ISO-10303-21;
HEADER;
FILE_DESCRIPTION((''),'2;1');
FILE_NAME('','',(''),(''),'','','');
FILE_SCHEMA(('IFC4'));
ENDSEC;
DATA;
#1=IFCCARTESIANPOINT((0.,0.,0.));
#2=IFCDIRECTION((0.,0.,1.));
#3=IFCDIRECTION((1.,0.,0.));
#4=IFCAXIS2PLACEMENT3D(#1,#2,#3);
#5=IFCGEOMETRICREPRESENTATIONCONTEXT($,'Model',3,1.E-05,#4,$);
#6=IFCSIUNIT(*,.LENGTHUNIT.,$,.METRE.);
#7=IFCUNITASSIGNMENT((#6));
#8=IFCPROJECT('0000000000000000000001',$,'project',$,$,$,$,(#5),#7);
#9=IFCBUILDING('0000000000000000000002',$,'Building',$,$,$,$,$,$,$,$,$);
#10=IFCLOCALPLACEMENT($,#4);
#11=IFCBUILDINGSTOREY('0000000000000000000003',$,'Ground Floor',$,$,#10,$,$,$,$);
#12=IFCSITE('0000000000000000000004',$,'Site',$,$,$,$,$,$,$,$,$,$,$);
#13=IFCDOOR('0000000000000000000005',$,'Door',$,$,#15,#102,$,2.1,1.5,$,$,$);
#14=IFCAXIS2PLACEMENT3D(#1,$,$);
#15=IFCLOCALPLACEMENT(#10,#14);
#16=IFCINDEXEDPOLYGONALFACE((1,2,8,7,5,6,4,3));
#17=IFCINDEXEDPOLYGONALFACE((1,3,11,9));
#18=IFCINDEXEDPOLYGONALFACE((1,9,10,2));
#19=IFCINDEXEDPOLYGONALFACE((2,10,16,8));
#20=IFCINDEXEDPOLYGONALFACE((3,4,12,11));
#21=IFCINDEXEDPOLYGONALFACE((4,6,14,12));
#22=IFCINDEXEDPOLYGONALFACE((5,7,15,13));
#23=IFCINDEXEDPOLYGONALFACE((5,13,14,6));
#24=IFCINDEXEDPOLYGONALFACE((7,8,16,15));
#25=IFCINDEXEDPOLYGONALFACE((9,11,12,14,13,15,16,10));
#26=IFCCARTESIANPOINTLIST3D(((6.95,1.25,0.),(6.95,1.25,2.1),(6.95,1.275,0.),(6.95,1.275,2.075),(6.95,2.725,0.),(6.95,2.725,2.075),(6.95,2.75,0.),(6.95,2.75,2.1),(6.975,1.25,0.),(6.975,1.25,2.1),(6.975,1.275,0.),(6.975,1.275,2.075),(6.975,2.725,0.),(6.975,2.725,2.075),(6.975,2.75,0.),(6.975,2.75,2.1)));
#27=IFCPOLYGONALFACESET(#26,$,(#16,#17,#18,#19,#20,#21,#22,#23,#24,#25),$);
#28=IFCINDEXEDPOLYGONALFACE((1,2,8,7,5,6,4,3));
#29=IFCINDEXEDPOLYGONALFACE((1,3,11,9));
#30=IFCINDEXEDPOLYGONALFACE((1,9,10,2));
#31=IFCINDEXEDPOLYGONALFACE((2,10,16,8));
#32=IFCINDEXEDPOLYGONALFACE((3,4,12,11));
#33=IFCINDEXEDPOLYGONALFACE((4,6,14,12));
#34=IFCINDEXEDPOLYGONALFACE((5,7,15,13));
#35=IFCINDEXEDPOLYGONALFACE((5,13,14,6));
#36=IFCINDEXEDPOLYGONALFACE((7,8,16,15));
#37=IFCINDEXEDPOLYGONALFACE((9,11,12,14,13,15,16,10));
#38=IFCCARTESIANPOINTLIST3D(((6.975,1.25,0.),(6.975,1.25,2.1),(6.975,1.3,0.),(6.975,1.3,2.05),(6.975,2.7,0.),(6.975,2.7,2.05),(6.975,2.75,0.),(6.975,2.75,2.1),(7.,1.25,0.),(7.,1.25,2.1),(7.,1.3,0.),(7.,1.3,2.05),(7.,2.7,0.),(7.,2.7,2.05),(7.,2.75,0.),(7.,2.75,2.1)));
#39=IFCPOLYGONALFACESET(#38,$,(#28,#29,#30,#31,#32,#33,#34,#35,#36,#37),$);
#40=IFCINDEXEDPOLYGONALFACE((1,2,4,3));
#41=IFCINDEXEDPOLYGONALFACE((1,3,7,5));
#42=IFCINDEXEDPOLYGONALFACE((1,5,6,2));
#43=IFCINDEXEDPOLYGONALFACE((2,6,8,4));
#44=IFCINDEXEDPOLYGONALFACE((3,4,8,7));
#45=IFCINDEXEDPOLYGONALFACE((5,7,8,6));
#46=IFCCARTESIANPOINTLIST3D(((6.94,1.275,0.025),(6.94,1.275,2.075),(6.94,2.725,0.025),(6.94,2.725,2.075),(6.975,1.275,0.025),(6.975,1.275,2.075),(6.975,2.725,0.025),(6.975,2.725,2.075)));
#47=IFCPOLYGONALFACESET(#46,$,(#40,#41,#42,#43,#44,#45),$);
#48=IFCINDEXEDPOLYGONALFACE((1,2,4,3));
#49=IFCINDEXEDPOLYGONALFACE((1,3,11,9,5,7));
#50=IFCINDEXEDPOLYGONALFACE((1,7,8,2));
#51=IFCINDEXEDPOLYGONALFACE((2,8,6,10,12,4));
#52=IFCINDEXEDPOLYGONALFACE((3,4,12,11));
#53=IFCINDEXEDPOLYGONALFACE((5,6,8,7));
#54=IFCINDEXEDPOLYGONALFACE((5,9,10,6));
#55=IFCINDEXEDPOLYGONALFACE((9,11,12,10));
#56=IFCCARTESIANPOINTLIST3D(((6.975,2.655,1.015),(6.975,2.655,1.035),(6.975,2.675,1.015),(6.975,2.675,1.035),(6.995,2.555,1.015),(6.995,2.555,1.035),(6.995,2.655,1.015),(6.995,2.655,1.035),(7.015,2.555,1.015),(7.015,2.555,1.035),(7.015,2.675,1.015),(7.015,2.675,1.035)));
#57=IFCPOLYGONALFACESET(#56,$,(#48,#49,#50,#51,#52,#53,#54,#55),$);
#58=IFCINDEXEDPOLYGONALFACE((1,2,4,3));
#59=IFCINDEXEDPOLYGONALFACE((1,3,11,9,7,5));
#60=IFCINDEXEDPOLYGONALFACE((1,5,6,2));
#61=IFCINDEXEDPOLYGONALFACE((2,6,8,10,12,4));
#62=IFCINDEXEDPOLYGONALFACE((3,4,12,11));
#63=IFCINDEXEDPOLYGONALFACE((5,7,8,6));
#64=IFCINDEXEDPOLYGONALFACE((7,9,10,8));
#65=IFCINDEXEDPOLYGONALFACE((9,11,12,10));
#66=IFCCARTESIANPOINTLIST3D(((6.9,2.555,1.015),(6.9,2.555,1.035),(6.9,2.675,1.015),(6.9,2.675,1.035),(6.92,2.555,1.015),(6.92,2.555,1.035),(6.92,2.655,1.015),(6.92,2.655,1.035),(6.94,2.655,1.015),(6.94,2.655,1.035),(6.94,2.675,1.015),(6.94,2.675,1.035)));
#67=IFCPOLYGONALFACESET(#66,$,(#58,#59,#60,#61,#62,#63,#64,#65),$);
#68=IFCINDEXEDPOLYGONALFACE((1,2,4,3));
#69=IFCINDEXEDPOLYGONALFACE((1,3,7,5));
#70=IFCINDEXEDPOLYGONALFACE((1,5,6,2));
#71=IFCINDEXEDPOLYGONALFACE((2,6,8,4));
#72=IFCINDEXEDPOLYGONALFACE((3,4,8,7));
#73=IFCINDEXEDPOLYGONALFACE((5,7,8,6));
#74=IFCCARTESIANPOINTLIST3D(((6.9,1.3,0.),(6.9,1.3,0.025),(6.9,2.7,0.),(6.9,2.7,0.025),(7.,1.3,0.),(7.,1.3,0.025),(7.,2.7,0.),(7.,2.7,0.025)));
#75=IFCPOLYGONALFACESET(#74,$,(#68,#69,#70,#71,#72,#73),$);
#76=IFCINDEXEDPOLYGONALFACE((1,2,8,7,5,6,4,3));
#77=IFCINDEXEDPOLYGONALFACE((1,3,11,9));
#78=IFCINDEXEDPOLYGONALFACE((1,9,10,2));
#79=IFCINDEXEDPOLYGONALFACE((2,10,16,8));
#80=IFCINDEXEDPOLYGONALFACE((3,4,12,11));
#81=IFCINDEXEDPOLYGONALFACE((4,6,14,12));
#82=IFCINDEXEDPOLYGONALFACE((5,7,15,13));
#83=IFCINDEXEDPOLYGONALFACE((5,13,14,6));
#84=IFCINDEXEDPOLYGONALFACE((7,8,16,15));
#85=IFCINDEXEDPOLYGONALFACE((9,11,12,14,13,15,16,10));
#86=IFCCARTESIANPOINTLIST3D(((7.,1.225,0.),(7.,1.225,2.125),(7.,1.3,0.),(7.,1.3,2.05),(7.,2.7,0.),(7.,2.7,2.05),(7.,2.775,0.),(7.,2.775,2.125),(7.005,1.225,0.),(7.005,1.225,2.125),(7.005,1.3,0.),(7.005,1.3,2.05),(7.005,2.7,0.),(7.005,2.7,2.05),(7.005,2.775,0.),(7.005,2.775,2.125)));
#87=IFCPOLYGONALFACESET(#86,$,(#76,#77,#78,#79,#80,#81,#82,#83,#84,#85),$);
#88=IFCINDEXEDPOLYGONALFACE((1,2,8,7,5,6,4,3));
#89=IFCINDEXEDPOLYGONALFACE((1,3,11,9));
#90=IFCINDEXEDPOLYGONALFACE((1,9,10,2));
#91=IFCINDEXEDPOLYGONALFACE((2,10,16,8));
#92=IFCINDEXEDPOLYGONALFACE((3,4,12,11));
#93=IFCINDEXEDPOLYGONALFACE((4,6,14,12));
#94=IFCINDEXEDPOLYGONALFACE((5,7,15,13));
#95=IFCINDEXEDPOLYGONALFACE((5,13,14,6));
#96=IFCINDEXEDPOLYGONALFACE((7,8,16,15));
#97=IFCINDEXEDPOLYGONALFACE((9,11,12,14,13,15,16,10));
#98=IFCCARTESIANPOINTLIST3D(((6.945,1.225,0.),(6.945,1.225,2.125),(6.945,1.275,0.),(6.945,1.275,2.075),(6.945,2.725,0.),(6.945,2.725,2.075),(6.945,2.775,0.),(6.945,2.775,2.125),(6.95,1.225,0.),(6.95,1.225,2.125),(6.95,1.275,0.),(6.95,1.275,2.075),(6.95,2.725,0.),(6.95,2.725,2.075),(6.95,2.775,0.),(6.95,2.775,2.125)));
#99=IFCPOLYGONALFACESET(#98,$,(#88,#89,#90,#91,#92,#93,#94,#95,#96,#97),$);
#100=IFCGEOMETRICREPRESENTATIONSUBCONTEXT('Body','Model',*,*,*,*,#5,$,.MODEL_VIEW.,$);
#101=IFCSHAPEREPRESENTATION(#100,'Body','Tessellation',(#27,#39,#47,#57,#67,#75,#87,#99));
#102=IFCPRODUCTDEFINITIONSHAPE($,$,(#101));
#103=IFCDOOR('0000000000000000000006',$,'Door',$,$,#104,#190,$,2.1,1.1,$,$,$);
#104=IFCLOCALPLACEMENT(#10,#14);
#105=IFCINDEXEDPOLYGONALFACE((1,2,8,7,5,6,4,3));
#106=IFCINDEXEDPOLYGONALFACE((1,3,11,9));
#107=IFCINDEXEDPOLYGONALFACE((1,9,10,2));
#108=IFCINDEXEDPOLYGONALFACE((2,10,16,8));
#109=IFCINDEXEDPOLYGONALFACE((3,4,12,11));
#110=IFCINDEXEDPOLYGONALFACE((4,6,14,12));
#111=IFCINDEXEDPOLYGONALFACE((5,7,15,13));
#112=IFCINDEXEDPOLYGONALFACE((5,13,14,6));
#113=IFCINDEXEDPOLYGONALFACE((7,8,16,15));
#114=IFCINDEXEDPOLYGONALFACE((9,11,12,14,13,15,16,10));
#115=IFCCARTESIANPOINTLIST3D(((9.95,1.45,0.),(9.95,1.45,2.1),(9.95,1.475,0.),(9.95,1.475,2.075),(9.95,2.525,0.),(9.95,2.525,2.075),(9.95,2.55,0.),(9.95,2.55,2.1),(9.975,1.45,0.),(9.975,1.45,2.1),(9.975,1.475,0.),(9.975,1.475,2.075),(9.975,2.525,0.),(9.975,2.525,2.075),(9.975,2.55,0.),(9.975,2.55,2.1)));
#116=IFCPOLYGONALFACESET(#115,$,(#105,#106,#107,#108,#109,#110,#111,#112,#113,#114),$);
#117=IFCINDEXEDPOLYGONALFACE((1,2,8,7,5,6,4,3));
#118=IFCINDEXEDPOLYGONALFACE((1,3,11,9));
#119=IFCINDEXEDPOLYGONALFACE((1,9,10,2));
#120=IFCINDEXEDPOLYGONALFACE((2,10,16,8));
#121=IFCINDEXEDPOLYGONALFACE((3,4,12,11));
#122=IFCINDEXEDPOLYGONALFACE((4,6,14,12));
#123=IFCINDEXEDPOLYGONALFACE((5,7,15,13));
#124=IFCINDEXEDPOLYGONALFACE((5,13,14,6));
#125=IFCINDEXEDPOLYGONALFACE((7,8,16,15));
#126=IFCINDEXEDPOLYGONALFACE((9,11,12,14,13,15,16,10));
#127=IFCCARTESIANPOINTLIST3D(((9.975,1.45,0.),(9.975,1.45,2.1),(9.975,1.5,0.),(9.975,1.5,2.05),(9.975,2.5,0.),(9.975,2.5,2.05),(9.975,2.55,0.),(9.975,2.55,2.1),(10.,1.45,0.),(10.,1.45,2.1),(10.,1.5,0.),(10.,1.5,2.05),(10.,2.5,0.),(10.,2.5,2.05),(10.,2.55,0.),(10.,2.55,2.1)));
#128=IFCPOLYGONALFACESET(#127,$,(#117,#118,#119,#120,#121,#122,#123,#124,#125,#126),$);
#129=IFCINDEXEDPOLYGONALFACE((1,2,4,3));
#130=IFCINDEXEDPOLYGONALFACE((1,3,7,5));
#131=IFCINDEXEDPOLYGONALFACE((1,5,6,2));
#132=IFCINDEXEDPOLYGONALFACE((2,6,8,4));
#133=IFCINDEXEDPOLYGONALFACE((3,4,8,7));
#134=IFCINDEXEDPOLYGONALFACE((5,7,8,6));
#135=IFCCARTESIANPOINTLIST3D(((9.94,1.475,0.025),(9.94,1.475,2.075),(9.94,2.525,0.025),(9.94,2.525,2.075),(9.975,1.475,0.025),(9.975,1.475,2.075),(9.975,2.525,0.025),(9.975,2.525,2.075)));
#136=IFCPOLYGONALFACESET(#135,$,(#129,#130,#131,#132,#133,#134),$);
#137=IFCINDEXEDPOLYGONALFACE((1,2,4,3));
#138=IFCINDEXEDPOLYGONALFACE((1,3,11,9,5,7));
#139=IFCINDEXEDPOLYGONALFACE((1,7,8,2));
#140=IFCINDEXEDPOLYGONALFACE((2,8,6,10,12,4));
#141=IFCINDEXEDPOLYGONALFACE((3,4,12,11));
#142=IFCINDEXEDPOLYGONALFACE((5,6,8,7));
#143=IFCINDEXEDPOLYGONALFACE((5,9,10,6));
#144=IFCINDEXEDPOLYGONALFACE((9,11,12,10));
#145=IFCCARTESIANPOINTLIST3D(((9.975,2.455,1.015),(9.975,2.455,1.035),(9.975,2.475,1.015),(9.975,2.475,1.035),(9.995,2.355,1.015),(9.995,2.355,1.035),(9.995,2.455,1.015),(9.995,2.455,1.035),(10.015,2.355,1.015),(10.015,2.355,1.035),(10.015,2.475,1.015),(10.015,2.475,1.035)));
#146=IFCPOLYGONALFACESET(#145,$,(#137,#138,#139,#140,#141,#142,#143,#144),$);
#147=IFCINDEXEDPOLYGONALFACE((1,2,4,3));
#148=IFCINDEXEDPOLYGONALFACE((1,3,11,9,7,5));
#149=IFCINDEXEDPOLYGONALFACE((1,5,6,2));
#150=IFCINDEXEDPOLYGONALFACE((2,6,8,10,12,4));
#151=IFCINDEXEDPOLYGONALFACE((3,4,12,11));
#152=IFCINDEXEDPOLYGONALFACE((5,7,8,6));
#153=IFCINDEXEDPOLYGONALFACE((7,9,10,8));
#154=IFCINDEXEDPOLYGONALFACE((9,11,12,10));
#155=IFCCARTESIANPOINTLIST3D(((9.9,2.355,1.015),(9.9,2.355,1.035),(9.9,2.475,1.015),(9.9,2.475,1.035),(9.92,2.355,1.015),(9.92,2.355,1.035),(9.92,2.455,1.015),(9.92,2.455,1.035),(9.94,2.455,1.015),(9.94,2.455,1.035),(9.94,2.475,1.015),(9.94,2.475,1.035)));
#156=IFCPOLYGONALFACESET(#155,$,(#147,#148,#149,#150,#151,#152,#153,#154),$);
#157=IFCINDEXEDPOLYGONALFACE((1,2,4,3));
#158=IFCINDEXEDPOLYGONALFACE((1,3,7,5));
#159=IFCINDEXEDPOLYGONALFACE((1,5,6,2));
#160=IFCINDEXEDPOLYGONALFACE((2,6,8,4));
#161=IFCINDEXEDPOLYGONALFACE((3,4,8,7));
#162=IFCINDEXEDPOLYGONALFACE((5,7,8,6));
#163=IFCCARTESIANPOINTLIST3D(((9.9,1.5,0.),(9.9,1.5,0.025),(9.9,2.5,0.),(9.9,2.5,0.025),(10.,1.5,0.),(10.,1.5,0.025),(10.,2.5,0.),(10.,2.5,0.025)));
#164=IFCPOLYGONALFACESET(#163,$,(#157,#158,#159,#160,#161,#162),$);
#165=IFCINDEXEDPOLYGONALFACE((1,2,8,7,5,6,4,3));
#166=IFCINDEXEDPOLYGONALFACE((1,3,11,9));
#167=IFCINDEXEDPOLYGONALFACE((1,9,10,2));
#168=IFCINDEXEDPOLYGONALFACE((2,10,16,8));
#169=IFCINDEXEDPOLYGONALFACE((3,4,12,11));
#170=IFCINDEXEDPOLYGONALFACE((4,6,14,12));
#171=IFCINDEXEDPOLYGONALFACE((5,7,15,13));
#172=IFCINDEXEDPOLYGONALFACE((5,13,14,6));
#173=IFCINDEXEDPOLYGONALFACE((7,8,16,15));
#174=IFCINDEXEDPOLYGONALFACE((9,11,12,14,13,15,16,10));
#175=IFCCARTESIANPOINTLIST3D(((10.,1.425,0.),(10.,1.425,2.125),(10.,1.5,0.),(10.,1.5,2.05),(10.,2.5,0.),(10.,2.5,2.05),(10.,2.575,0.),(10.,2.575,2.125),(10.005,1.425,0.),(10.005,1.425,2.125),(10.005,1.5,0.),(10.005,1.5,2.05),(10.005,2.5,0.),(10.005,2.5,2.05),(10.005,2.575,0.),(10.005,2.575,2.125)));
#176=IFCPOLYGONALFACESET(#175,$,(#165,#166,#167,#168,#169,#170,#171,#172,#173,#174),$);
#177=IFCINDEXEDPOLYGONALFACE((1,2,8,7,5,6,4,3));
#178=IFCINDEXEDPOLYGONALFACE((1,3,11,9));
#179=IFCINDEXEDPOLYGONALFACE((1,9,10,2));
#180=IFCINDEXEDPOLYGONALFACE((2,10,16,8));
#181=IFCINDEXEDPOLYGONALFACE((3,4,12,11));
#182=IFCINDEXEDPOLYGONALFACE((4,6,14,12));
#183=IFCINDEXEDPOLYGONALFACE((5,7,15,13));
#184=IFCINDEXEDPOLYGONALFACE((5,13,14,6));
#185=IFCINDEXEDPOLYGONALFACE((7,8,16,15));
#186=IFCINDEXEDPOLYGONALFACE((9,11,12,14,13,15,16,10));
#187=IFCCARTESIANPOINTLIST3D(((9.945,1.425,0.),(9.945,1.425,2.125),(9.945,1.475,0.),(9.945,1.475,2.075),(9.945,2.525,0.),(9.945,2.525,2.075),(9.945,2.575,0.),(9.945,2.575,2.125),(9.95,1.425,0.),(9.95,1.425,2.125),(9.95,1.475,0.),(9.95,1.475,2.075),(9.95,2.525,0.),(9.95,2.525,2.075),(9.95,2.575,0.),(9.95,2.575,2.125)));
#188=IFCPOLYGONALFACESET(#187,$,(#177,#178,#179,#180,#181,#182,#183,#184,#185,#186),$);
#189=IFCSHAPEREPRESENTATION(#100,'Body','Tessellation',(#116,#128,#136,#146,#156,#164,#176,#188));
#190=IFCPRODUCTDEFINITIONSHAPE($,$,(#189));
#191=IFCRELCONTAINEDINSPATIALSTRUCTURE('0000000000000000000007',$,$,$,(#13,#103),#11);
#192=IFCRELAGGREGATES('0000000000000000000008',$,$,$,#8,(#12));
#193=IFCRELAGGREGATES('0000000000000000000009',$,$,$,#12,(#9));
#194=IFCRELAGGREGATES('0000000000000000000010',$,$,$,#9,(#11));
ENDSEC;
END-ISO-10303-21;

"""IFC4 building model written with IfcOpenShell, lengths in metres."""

from ifc_helpers import new_model, si_unit, frame, origin_with_axes, place, context, subcontext, project, spatial, line, indexed_curve, outline, extrude, element, save


model = new_model("IFC4")

# Units and contexts
model_context = context("Model", 3, precision=1e-05, world=origin_with_axes())
body_context = subcontext(model_context, "Body", "Model", "MODEL_VIEW")
ifc_project = project(units=[si_unit("LENGTHUNIT", "METRE")], contexts=[model_context])

# Site, building, storey
site = spatial("IfcSite", under=ifc_project, Name="Site")
building = spatial("IfcBuilding", under=site, Name="Building")
storey_placement = place(None, origin_with_axes())
storey = spatial("IfcBuildingStorey", under=building, at=storey_placement, Name="Ground Floor")

# Doors
door_1_placement = place(storey_placement, frame((7.0, 1.25, 0.0), z_axis=(0.0, 0.0, 1.0), x_axis=(0.0, 1.0, 0.0)))
element("IfcDoor", 1, at=door_1_placement, inside=storey, Name="Door", OverallHeight=2.1, OverallWidth=1.5, context=body_context, shape_type="SweptSolid", body=[
    extrude(outline(indexed_curve([(0.0, 0.0), (0.0, 2.1), (1.5, 2.1), (1.5, 0.0), (1.475, 0.0), (1.475, 2.075), (0.025, 2.075), (0.025, 0.0)], segments=[line(1, 2, 3, 4, 5, 6, 7, 8, 1)])), frame((0.0, 0.025, 0.0), z_axis=(0.0, -1.0, 0.0), x_axis=(1.0, 0.0, 0.0)), (0.0, 0.0, -1.0), 0.025),
    extrude(outline(indexed_curve([(0.0, 0.0), (0.0, 2.1), (1.5, 2.1), (1.5, 0.0), (1.45, 0.0), (1.45, 2.05), (0.05, 2.05), (0.05, 0.0)], segments=[line(1, 2, 3, 4, 5, 6, 7, 8, 1)])), frame((0.0, 0.0, 0.0), z_axis=(0.0, -1.0, 0.0), x_axis=(1.0, 0.0, 0.0)), (0.0, 0.0, -1.0), 0.025),
    extrude(outline(indexed_curve([(0.0, 0.0), (1.45, 0.0), (1.45, 0.035), (0.0, 0.035)], segments=[line(1, 2, 3, 4, 1)])), frame((0.025, 0.025, 0.025), z_axis=(0.0, 0.0, 1.0), x_axis=(1.0, 0.0, 0.0)), (0.0, 0.0, 1.0), 2.05),
    extrude(outline(indexed_curve([(0.0, 0.0), (0.0, -0.04), (-0.12, -0.04), (-0.12, -0.02), (-0.02, -0.02), (-0.02, 0.0)], segments=[line(1, 2, 3, 4, 5, 6, 1)])), frame((1.425, 0.025, 1.015), z_axis=(0.0, 0.0, 1.0), x_axis=(1.0, 0.0, 0.0)), (0.0, 0.0, 1.0), 0.02),
    extrude(outline(indexed_curve([(0.0, 0.0), (0.0, 0.04), (-0.12, 0.04), (-0.12, 0.02), (-0.02, 0.02), (-0.02, 0.0)], segments=[line(1, 2, 3, 4, 5, 6, 1)])), frame((1.425, 0.06, 1.015), z_axis=(0.0, 0.0, 1.0), x_axis=(1.0, 0.0, 0.0)), (0.0, 0.0, 1.0), 0.02),
    extrude(outline(indexed_curve([(0.0, 0.0), (1.4, 0.0), (1.4, 0.1), (0.0, 0.1)], segments=[line(1, 2, 3, 4, 1)])), frame((0.05, 0.0, 0.0), z_axis=(0.0, 0.0, 1.0), x_axis=(1.0, 0.0, 0.0)), (0.0, 0.0, 1.0), 0.025),
    extrude(outline(indexed_curve([(0.0, 0.0), (0.0, 2.125), (1.55, 2.125), (1.55, 0.0), (1.475, 0.0), (1.475, 2.05), (0.075, 2.05), (0.075, 0.0)], segments=[line(1, 2, 3, 4, 5, 6, 7, 8, 1)])), frame((-0.025, -0.005, 0.0), z_axis=(0.0, -1.0, 0.0), x_axis=(1.0, 0.0, 0.0)), (0.0, 0.0, -1.0), 0.005),
    extrude(outline(indexed_curve([(0.0, 0.0), (0.0, 2.125), (1.55, 2.125), (1.55, 0.0), (1.5, 0.0), (1.5, 2.075), (0.05, 2.075), (0.05, 0.0)], segments=[line(1, 2, 3, 4, 5, 6, 7, 8, 1)])), frame((-0.025, 0.05, 0.0), z_axis=(0.0, -1.0, 0.0), x_axis=(1.0, 0.0, 0.0)), (0.0, 0.0, -1.0), 0.005),
])
door_2_placement = place(storey_placement, frame((10.0, 1.45, 0.0), z_axis=(0.0, 0.0, 1.0), x_axis=(0.0, 1.0, 0.0)))
element("IfcDoor", 2, at=door_2_placement, inside=storey, Name="Door", OverallHeight=2.1, OverallWidth=1.1, context=body_context, shape_type="SweptSolid", body=[
    extrude(outline(indexed_curve([(0.0, 0.0), (0.0, 2.1), (1.1, 2.1), (1.1, 0.0), (1.075, 0.0), (1.075, 2.075), (0.025, 2.075), (0.025, 0.0)], segments=[line(1, 2, 3, 4, 5, 6, 7, 8, 1)])), frame((0.0, 0.025, 0.0), z_axis=(0.0, -1.0, 0.0), x_axis=(1.0, 0.0, 0.0)), (0.0, 0.0, -1.0), 0.025),
    extrude(outline(indexed_curve([(0.0, 0.0), (0.0, 2.1), (1.1, 2.1), (1.1, 0.0), (1.05, 0.0), (1.05, 2.05), (0.05, 2.05), (0.05, 0.0)], segments=[line(1, 2, 3, 4, 5, 6, 7, 8, 1)])), frame((0.0, 0.0, 0.0), z_axis=(0.0, -1.0, 0.0), x_axis=(1.0, 0.0, 0.0)), (0.0, 0.0, -1.0), 0.025),
    extrude(outline(indexed_curve([(0.0, 0.0), (1.05, 0.0), (1.05, 0.035), (0.0, 0.035)], segments=[line(1, 2, 3, 4, 1)])), frame((0.025, 0.025, 0.025), z_axis=(0.0, 0.0, 1.0), x_axis=(1.0, 0.0, 0.0)), (0.0, 0.0, 1.0), 2.05),
    extrude(outline(indexed_curve([(0.0, 0.0), (0.0, -0.04), (-0.12, -0.04), (-0.12, -0.02), (-0.02, -0.02), (-0.02, 0.0)], segments=[line(1, 2, 3, 4, 5, 6, 1)])), frame((1.025, 0.025, 1.015), z_axis=(0.0, 0.0, 1.0), x_axis=(1.0, 0.0, 0.0)), (0.0, 0.0, 1.0), 0.02),
    extrude(outline(indexed_curve([(0.0, 0.0), (0.0, 0.04), (-0.12, 0.04), (-0.12, 0.02), (-0.02, 0.02), (-0.02, 0.0)], segments=[line(1, 2, 3, 4, 5, 6, 1)])), frame((1.025, 0.06, 1.015), z_axis=(0.0, 0.0, 1.0), x_axis=(1.0, 0.0, 0.0)), (0.0, 0.0, 1.0), 0.02),
    extrude(outline(indexed_curve([(0.0, 0.0), (1.0, 0.0), (1.0, 0.1), (0.0, 0.1)], segments=[line(1, 2, 3, 4, 1)])), frame((0.05, 0.0, 0.0), z_axis=(0.0, 0.0, 1.0), x_axis=(1.0, 0.0, 0.0)), (0.0, 0.0, 1.0), 0.025),
    extrude(outline(indexed_curve([(0.0, 0.0), (0.0, 2.125), (1.15, 2.125), (1.15, 0.0), (1.075, 0.0), (1.075, 2.05), (0.075, 2.05), (0.075, 0.0)], segments=[line(1, 2, 3, 4, 5, 6, 7, 8, 1)])), frame((-0.025, -0.005, 0.0), z_axis=(0.0, -1.0, 0.0), x_axis=(1.0, 0.0, 0.0)), (0.0, 0.0, -1.0), 0.005),
    extrude(outline(indexed_curve([(0.0, 0.0), (0.0, 2.125), (1.15, 2.125), (1.15, 0.0), (1.1, 0.0), (1.1, 2.075), (0.05, 2.075), (0.05, 0.0)], segments=[line(1, 2, 3, 4, 5, 6, 7, 8, 1)])), frame((-0.025, 0.05, 0.0), z_axis=(0.0, -1.0, 0.0), x_axis=(1.0, 0.0, 0.0)), (0.0, 0.0, -1.0), 0.005),
])

save(model, "model.ifc")
